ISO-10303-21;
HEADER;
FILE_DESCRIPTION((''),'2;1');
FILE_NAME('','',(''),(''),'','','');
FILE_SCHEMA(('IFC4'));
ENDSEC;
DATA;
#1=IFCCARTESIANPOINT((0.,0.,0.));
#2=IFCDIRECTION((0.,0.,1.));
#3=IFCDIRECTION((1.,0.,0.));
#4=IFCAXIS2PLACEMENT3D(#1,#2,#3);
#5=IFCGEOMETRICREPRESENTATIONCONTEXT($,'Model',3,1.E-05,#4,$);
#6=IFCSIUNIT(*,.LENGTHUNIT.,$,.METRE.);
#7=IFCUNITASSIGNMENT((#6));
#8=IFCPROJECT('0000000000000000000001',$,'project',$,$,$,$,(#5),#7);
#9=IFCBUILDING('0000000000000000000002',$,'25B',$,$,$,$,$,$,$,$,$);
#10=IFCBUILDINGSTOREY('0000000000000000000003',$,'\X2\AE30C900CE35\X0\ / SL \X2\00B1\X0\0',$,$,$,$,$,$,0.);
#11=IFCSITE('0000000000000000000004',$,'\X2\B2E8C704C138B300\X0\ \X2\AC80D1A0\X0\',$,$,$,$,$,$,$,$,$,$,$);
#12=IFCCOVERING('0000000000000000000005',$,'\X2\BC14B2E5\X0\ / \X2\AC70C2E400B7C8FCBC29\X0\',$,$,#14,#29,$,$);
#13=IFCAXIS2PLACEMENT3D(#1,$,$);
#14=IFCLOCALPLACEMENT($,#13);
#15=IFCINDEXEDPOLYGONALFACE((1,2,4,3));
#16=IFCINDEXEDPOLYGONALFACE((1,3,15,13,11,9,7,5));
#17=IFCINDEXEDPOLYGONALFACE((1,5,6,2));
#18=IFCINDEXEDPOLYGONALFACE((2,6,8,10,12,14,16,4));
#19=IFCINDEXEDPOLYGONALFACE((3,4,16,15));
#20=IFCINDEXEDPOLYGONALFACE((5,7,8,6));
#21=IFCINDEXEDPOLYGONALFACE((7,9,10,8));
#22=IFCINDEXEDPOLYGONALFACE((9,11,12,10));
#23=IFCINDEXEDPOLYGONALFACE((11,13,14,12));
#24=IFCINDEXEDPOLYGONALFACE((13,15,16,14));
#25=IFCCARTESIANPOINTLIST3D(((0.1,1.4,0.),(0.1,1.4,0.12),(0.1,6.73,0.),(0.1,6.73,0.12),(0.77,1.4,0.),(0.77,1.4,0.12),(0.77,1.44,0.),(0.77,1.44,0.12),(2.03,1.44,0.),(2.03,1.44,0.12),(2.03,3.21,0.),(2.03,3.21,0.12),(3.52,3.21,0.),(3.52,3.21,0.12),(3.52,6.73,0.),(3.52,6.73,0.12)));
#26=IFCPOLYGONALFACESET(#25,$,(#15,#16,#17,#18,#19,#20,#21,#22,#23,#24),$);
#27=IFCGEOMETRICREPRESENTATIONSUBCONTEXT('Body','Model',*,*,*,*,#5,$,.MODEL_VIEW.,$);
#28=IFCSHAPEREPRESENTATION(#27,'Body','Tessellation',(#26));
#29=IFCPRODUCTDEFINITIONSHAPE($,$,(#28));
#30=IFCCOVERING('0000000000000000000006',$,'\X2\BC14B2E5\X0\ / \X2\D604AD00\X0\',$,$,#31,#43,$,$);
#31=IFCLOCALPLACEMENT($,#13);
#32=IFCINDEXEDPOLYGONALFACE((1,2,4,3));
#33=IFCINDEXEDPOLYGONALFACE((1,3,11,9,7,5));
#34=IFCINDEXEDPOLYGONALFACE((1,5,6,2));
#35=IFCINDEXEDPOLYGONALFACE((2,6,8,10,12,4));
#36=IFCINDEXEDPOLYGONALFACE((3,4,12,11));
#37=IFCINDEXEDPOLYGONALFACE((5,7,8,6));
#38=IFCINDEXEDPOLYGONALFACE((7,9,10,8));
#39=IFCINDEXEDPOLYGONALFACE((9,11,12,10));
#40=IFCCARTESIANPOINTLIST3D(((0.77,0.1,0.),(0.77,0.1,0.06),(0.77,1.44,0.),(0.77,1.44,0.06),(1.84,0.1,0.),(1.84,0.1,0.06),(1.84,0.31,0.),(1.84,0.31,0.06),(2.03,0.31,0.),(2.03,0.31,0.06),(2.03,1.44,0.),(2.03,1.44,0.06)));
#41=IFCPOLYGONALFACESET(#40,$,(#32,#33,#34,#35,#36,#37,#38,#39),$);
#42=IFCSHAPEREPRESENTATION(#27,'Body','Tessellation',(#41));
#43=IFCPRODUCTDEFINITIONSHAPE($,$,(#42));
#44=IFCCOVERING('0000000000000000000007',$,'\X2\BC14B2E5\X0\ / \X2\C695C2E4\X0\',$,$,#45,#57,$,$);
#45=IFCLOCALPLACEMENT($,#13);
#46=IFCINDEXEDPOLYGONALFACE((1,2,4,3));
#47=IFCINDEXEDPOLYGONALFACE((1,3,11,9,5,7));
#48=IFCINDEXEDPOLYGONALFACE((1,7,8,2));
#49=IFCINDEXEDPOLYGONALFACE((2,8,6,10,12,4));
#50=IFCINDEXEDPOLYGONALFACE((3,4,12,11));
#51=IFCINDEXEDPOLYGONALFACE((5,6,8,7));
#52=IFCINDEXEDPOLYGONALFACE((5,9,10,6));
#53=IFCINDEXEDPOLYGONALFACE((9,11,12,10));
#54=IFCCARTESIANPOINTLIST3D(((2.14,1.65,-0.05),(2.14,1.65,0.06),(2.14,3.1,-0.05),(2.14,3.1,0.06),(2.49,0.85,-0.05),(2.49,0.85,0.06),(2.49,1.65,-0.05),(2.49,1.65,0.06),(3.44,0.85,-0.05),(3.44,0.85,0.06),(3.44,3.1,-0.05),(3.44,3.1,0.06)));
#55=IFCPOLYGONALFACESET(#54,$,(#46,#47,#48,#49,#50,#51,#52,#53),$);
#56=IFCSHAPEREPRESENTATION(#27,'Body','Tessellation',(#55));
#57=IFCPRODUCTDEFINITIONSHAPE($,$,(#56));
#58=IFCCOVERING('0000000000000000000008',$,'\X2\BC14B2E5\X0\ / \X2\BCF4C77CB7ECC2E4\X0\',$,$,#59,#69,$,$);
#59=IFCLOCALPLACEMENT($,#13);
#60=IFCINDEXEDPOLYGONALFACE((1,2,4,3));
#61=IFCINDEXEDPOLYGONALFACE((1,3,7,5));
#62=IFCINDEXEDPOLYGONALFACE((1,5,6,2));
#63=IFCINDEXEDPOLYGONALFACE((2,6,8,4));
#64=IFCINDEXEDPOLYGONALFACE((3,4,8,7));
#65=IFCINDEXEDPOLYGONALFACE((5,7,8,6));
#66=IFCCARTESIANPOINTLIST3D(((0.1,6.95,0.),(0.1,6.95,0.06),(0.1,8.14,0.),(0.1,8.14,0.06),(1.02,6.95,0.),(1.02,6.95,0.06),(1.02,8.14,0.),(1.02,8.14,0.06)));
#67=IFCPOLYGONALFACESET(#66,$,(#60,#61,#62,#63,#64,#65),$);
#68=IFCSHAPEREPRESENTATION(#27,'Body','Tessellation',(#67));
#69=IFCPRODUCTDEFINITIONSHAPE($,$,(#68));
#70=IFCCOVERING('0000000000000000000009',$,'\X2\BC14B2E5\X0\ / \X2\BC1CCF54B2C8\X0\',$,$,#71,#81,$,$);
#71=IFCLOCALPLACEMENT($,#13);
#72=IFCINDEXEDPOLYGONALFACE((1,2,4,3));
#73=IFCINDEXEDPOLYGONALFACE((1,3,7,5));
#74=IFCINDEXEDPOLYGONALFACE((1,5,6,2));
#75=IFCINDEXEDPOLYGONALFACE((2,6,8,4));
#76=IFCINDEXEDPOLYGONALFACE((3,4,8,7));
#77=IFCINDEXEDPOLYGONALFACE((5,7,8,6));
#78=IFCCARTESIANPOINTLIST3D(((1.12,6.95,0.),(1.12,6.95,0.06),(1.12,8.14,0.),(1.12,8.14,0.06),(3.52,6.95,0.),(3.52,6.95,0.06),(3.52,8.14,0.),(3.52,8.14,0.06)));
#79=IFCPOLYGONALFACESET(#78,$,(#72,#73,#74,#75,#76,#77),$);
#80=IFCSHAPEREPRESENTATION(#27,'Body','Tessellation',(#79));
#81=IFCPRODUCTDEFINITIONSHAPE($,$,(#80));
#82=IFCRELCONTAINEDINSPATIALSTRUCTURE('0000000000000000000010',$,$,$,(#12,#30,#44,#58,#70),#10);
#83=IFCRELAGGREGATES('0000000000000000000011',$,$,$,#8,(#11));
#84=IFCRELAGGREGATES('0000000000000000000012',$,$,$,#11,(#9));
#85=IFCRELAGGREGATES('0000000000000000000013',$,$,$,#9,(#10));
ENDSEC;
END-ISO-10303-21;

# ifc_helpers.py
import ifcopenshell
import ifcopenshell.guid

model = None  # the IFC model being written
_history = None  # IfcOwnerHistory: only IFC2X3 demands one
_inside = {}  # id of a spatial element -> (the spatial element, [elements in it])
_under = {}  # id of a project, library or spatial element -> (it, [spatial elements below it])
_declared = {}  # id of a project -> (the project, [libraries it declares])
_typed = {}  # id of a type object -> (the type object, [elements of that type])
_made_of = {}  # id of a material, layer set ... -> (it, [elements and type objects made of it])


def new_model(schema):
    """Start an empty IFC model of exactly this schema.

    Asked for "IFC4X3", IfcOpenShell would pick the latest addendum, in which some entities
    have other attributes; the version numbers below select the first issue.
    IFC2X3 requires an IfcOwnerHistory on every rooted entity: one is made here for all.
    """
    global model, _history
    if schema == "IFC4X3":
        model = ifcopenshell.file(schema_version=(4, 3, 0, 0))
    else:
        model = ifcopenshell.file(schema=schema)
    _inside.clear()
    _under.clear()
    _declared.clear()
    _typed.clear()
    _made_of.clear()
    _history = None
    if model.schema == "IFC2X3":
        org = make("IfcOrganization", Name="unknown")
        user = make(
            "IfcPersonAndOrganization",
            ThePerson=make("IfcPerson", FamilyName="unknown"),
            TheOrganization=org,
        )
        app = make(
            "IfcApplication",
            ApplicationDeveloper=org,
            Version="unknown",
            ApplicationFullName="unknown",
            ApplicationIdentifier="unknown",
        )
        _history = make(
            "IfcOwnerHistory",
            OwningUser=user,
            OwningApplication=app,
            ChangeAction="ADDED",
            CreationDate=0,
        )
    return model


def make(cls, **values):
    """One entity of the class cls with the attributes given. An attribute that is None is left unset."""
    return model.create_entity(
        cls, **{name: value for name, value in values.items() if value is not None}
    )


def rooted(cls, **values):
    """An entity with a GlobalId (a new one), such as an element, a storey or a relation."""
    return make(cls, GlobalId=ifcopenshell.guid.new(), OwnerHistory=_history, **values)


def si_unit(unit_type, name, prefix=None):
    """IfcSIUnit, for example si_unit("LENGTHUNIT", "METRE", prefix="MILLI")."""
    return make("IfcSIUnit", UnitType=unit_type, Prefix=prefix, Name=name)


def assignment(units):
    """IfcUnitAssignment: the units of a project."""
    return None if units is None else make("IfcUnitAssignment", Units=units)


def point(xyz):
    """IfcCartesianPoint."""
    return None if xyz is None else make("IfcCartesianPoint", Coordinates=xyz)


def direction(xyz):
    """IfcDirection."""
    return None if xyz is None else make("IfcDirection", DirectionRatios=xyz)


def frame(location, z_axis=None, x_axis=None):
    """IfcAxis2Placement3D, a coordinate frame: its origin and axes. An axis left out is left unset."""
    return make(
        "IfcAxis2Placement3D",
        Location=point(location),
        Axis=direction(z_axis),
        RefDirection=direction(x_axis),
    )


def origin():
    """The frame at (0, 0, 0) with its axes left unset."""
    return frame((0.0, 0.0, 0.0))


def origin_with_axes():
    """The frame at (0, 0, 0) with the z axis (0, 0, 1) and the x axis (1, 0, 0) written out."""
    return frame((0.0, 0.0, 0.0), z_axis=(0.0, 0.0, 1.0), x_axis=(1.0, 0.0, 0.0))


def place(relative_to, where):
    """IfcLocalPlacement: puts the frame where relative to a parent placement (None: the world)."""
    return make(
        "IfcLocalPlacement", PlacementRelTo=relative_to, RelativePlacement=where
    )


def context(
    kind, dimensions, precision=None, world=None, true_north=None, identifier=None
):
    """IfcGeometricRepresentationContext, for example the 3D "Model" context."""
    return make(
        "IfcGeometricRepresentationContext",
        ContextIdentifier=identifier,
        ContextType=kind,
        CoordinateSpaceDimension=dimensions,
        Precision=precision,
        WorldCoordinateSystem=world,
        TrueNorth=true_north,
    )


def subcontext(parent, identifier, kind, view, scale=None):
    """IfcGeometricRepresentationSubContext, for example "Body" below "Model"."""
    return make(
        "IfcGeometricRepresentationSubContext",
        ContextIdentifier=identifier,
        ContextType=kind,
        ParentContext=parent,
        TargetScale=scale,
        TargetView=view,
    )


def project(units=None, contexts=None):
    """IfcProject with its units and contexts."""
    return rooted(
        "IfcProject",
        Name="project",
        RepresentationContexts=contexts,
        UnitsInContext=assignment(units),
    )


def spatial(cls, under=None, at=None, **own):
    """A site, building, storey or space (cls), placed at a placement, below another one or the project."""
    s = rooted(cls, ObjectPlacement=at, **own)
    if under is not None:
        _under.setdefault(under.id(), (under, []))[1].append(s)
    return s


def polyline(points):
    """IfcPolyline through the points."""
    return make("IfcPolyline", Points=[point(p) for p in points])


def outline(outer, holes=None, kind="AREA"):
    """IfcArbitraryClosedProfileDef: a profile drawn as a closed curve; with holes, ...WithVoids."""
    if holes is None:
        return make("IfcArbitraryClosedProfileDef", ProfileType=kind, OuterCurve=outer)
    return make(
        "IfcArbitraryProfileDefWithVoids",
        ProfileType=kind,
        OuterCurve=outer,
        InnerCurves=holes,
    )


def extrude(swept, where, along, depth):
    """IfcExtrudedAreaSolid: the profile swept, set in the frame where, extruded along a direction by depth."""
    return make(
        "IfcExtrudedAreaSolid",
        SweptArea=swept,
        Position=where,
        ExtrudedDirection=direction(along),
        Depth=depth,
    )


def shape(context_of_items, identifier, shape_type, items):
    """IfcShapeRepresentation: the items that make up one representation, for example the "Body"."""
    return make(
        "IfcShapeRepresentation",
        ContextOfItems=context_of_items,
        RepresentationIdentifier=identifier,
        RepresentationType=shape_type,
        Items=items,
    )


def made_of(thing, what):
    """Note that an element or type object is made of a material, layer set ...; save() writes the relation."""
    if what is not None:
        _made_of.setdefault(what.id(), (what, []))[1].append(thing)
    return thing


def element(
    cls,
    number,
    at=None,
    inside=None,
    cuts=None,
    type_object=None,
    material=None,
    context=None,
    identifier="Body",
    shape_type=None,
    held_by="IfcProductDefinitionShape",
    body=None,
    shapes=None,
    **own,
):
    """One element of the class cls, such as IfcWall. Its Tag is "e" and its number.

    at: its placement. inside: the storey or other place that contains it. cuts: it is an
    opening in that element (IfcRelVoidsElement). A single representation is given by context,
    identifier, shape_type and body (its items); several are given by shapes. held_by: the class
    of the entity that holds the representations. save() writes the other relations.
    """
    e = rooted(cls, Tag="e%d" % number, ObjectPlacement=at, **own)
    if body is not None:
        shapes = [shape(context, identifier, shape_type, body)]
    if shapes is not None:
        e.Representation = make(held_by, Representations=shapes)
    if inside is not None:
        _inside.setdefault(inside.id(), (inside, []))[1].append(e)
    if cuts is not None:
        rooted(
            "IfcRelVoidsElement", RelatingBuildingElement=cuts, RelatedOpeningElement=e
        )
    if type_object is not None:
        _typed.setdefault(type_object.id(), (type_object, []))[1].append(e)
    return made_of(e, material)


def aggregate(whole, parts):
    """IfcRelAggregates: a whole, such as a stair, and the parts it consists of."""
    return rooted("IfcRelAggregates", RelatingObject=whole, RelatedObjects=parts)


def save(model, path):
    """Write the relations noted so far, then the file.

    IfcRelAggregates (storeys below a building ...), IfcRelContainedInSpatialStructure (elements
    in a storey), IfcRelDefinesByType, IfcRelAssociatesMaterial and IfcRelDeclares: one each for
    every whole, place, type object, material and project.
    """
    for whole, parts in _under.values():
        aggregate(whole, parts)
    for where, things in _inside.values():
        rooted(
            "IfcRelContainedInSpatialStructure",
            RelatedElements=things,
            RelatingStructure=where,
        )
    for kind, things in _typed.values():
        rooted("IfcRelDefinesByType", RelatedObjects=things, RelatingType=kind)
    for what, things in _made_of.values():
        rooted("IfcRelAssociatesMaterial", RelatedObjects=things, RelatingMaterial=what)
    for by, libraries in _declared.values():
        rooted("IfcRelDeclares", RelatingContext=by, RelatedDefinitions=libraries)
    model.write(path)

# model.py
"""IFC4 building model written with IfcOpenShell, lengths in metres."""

from ifc_helpers import new_model, si_unit, frame, origin, origin_with_axes, place, context, subcontext, project, spatial, polyline, outline, extrude, element, save


model = new_model("IFC4")

# Units and contexts
model_context = context("Model", 3, precision=1e-05, world=origin_with_axes())
body_context = subcontext(model_context, "Body", "Model", "MODEL_VIEW")
ifc_project = project(units=[si_unit("LENGTHUNIT", "METRE")], contexts=[model_context])

# Site, building, storey
site = spatial("IfcSite", under=ifc_project, Name="단위세대 검토")
building = spatial("IfcBuilding", under=site, Name="25B")
storey = spatial("IfcBuildingStorey", under=building, Name="기준층 / SL ±0", Elevation=0.0)

# Coverings
covering_1_placement = place(None, origin_with_axes())
element("IfcCovering", 1, at=covering_1_placement, inside=storey, Name="바닥 / 거실·주방", context=body_context, shape_type="SweptSolid", body=[
    extrude(outline(polyline([(0.1, 1.4), (0.77, 1.4), (0.77, 1.44), (2.03, 1.44), (2.03, 3.21), (3.52, 3.21), (3.52, 6.73), (0.1, 6.73), (0.1, 1.4)])), origin(), (0.0, 0.0, 1.0), 0.12),
])
covering_2_placement = place(None, origin_with_axes())
element("IfcCovering", 2, at=covering_2_placement, inside=storey, Name="바닥 / 현관", context=body_context, shape_type="SweptSolid", body=[
    extrude(outline(polyline([(0.77, 0.1), (1.84, 0.1), (1.84, 0.31), (2.03, 0.31), (2.03, 1.44), (0.77, 1.44), (0.77, 0.1)])), origin(), (0.0, 0.0, 1.0), 0.06),
])
covering_3_placement = place(None, origin_with_axes())
element("IfcCovering", 3, at=covering_3_placement, inside=storey, Name="바닥 / 욕실", context=body_context, shape_type="SweptSolid", body=[
    extrude(outline(polyline([(2.14, 1.65), (2.49, 1.65), (2.49, 0.85), (3.44, 0.85), (3.44, 3.1), (2.14, 3.1), (2.14, 1.65)])), frame((0.0, 0.0, -0.05)), (0.0, 0.0, 1.0), 0.11),
])
covering_4_placement = place(None, origin_with_axes())
element("IfcCovering", 4, at=covering_4_placement, inside=storey, Name="바닥 / 보일러실", context=body_context, shape_type="SweptSolid", body=[
    extrude(outline(polyline([(1.02, 6.95), (1.02, 8.14), (0.1, 8.14), (0.1, 6.95), (1.02, 6.95)])), origin(), (0.0, 0.0, 1.0), 0.06),
])
covering_5_placement = place(None, origin_with_axes())
element("IfcCovering", 5, at=covering_5_placement, inside=storey, Name="바닥 / 발코니", context=body_context, shape_type="SweptSolid", body=[
    extrude(outline(polyline([(3.52, 6.95), (3.52, 8.14), (1.12, 8.14), (1.12, 6.95), (3.52, 6.95)])), origin(), (0.0, 0.0, 1.0), 0.06),
])

save(model, "model.ifc")
